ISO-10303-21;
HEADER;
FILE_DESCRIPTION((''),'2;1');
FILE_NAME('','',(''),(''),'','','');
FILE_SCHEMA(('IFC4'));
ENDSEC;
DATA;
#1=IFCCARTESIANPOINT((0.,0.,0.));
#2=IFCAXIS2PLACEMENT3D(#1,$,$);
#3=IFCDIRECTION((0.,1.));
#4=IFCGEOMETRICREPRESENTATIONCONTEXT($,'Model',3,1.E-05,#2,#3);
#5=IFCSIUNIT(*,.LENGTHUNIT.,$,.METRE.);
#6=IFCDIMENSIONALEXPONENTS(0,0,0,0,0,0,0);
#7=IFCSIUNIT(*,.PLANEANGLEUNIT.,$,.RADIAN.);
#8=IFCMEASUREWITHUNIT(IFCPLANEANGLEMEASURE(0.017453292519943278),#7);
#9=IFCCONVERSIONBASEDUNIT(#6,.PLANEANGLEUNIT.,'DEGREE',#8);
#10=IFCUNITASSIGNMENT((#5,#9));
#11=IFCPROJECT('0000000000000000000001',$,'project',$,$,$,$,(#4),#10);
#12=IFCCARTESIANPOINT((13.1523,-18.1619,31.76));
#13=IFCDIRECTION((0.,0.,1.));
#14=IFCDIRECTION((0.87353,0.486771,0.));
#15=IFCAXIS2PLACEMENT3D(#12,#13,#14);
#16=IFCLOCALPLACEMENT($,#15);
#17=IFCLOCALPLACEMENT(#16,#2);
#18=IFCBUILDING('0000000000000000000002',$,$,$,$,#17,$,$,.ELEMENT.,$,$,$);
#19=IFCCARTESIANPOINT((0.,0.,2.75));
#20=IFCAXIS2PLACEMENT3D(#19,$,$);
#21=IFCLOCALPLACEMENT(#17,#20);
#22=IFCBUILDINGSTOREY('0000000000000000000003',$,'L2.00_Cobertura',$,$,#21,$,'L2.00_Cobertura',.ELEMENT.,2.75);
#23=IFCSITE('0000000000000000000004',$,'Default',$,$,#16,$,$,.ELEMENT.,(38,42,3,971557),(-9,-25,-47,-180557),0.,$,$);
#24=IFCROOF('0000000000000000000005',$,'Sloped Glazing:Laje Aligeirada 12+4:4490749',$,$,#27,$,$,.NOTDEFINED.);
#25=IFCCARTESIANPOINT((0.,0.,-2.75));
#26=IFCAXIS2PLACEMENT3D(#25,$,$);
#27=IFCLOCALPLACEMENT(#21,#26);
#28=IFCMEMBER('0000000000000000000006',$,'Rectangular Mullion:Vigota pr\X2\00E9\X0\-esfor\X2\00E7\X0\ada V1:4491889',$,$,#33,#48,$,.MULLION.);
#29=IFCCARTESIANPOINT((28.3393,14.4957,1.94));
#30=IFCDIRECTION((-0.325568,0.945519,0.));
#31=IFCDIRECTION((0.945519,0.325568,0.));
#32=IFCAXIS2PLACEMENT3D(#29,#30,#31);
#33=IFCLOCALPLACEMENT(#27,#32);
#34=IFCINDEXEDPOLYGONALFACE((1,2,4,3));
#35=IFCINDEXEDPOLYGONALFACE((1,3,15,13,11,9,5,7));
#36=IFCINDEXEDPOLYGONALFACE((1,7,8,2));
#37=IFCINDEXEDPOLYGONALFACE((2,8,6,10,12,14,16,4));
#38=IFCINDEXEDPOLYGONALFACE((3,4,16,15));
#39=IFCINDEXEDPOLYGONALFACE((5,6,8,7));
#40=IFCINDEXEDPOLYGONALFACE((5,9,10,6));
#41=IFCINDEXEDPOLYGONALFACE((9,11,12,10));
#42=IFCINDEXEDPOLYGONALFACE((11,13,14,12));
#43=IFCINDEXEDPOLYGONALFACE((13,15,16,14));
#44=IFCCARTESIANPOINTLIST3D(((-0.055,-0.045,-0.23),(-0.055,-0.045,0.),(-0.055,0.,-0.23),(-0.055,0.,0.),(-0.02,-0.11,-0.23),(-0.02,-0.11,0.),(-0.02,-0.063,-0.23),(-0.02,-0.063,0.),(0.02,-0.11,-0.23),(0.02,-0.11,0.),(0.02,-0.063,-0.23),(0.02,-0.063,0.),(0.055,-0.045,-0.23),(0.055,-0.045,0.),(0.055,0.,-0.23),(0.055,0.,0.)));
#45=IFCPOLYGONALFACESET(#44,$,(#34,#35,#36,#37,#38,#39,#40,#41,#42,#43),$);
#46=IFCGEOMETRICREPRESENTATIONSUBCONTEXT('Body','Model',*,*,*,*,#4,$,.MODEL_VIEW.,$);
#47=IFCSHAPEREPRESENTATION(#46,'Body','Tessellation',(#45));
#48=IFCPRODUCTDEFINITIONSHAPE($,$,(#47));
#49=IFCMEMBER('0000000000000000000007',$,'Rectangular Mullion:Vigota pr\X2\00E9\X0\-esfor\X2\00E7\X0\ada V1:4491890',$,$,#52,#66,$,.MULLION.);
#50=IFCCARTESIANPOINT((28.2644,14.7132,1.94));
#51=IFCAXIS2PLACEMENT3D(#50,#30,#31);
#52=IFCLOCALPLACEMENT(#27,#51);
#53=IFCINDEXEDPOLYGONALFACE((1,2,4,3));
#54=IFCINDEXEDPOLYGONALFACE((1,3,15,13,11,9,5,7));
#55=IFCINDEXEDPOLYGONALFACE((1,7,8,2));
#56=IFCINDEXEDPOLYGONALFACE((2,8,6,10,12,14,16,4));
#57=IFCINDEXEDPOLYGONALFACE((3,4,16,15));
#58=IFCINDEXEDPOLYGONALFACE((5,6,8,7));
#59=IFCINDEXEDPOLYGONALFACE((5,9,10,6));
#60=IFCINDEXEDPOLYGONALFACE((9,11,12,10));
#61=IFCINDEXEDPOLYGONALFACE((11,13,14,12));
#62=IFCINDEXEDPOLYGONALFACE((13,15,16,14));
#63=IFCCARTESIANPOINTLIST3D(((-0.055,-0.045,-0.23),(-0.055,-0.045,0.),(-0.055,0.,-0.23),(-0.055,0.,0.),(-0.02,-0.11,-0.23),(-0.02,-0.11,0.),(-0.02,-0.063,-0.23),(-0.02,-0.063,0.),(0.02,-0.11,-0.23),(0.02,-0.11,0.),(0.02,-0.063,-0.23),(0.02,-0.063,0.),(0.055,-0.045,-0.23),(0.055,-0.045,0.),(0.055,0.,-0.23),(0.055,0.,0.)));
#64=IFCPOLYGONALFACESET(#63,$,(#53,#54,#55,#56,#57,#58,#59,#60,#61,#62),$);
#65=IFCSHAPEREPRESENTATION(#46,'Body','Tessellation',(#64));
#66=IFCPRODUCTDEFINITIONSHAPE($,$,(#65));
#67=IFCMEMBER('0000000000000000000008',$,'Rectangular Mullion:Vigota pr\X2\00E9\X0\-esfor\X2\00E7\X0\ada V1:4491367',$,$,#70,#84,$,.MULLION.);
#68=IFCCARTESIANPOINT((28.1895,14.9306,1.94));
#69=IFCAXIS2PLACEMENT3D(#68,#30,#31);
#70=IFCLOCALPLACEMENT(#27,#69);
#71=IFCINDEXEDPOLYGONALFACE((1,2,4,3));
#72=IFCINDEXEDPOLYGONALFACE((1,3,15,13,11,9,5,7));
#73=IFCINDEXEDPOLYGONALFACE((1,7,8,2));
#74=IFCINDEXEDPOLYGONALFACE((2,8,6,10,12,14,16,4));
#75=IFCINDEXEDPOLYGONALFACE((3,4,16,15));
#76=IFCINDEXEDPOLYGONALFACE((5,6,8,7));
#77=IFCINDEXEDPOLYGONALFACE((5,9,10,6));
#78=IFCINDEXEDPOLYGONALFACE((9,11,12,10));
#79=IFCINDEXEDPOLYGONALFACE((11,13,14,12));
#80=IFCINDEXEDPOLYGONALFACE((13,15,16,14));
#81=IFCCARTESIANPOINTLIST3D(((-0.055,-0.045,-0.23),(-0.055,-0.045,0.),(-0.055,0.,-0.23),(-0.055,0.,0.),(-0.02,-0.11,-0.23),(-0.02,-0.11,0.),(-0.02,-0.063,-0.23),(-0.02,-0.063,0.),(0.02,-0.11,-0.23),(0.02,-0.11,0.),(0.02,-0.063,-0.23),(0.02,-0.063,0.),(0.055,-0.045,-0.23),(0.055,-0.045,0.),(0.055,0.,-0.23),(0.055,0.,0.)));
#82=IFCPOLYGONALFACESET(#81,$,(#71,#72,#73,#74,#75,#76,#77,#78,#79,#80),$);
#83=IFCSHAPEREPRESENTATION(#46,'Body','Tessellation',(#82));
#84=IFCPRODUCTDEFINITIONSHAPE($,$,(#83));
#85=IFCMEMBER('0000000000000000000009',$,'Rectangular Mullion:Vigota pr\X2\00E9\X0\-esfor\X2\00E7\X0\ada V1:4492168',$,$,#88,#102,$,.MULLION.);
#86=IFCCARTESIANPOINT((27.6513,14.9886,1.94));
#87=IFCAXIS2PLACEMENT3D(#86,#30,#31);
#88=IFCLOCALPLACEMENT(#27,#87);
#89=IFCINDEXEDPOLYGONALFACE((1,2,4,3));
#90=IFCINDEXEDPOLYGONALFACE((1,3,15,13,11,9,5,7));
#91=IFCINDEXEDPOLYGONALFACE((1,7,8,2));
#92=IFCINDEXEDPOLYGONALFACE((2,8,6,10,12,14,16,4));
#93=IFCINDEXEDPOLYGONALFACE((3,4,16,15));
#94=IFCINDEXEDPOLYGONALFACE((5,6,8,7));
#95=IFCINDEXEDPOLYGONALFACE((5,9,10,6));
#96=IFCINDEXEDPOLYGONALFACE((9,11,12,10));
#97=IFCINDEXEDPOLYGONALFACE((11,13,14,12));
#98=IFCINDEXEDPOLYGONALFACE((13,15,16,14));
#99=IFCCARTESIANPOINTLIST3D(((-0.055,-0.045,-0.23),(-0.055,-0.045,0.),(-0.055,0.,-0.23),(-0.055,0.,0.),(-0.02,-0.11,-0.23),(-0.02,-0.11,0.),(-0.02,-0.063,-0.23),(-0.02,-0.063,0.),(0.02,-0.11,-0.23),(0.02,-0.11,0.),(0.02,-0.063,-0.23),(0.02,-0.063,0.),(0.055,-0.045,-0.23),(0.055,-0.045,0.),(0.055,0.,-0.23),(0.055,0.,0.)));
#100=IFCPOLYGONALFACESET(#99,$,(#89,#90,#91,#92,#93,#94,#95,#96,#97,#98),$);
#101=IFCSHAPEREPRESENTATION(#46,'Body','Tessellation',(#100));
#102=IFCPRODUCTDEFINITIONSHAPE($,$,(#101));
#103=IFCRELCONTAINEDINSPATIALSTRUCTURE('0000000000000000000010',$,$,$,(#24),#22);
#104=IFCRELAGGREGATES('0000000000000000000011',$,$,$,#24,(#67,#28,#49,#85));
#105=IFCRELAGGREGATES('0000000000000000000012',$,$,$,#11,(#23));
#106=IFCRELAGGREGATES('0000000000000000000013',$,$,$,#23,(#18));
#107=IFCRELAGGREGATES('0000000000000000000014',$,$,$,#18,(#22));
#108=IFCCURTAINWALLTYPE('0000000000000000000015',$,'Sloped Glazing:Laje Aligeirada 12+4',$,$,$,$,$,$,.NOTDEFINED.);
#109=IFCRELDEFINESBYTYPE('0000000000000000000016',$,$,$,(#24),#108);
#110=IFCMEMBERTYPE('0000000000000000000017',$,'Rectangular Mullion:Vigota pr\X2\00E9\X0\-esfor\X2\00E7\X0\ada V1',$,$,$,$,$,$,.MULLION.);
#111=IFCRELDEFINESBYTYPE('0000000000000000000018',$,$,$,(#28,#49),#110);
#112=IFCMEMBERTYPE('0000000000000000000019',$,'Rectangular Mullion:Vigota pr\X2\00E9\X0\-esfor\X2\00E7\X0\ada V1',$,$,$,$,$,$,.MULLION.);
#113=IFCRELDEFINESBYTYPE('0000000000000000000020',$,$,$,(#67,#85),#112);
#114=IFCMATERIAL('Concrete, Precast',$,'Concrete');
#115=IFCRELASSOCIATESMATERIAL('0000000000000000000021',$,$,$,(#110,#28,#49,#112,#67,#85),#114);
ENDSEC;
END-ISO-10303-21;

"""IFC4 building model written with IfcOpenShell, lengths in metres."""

from ifc_helpers import new_model, entity, si_unit, converted_unit, direction, frame, origin, place, context, subcontext, project, spatial, indexed_curve, outline, extrude, source, transform, mapped, material, type_object, type_shapes, element, aggregate, save


model = new_model("IFC4")

# Units and contexts
model_context = context("Model", 3, precision=1e-05, world=origin(), true_north=direction((0.0, 1.0)))
body_context = subcontext(model_context, "Body", "Model", "MODEL_VIEW")
ifc_project = project(units=[si_unit("LENGTHUNIT", "METRE"), converted_unit("PLANEANGLEUNIT", "DEGREE", entity("IfcPlaneAngleMeasure", 0.017453292519943278), si_unit("PLANEANGLEUNIT", "RADIAN"), dimensions=[0, 0, 0, 0, 0, 0, 0])], contexts=[model_context])

# Site, building, storey
site_placement = place(None, frame((13.1523, -18.1619, 31.76), z_axis=(0.0, 0.0, 1.0), x_axis=(0.87353, 0.486771, 0.0)))
site = spatial("IfcSite", under=ifc_project, at=site_placement, Name="Default", CompositionType="ELEMENT", RefLatitude=(38, 42, 3, 971557), RefLongitude=(-9, -25, -47, -180557), RefElevation=0.0)
building_placement = place(site_placement, origin())
building = spatial("IfcBuilding", under=site, at=building_placement, CompositionType="ELEMENT")
storey_placement = place(building_placement, frame((0.0, 0.0, 2.75)))
storey = spatial("IfcBuildingStorey", under=building, at=storey_placement, Name="L2.00_Cobertura", LongName="L2.00_Cobertura", CompositionType="ELEMENT", Elevation=2.75)

# Roof, members
curtain_wall_type = type_object("IfcCurtainWallType", Name="Sloped Glazing:Laje Aligeirada 12+4", PredefinedType="NOTDEFINED")
roof_placement = place(storey_placement, frame((0.0, 0.0, -2.75)))
roof = element("IfcRoof", 1, at=roof_placement, inside=storey, type_object=curtain_wall_type, Name="Sloped Glazing:Laje Aligeirada 12+4:4490749", PredefinedType="NOTDEFINED")
ifc_material_1 = material(Name="Concrete, Precast", Category="Concrete")
member_type_1 = type_object("IfcMemberType", Name="Rectangular Mullion:Vigota pré-esforçada V1", PredefinedType="MULLION", material=ifc_material_1)
shared_shape_1 = source(origin(), body_context, "Body", "SweptSolid", [
    extrude(outline(indexed_curve([(-0.055, -0.0545), (0.055, -0.0545), (0.055, -0.0095), (0.02, 0.0085), (0.02, 0.0555), (-0.02, 0.0555), (-0.02, 0.0085), (-0.055, -0.0095), (-0.055, -0.0545)], self_intersect=False)), frame((0.0, -0.0545, -0.23), z_axis=(0.0, 0.0, 1.0), x_axis=(-1.0, 0.0, 0.0)), (0.0, 0.0, 1.0), 0.23),
])
type_shapes(member_type_1, [shared_shape_1])
member_1_placement = place(roof_placement, frame((28.3393, 14.4957, 1.94), z_axis=(-0.325568, 0.945519, 0.0), x_axis=(0.945519, 0.325568, 0.0)))
member_1 = element("IfcMember", 2, at=member_1_placement, type_object=member_type_1, material=ifc_material_1, Name="Rectangular Mullion:Vigota pré-esforçada V1:4491889", PredefinedType="MULLION", context=body_context, shape_type="MappedRepresentation", body=[
    mapped(shared_shape_1, transform((0.0, 0.0, 0.0), scale=1.0)),
])
member_2_placement = place(roof_placement, frame((28.2644, 14.7132, 1.94), z_axis=(-0.325568, 0.945519, 0.0), x_axis=(0.945519, 0.325568, 0.0)))
member_2 = element("IfcMember", 3, at=member_2_placement, type_object=member_type_1, material=ifc_material_1, Name="Rectangular Mullion:Vigota pré-esforçada V1:4491890", PredefinedType="MULLION", context=body_context, shape_type="MappedRepresentation", body=[
    mapped(shared_shape_1, transform((0.0, 0.0, 0.0), scale=1.0)),
])
member_type_2 = type_object("IfcMemberType", Name="Rectangular Mullion:Vigota pré-esforçada V1", PredefinedType="MULLION", material=ifc_material_1)
shared_shape_2 = source(origin(), body_context, "Body", "SweptSolid", [
    extrude(outline(indexed_curve([(-0.055, -0.0545), (0.055, -0.0545), (0.055, -0.0095), (0.02, 0.0085), (0.02, 0.0555), (-0.02, 0.0555), (-0.02, 0.0085), (-0.055, -0.0095), (-0.055, -0.0545)], self_intersect=False)), frame((0.0, -0.0545, -0.23), z_axis=(0.0, 0.0, 1.0), x_axis=(-1.0, 0.0, 0.0)), (0.0, 0.0, 1.0), 0.23),
])
type_shapes(member_type_2, [shared_shape_2])
member_3_placement = place(roof_placement, frame((28.1895, 14.9306, 1.94), z_axis=(-0.325568, 0.945519, 0.0), x_axis=(0.945519, 0.325568, 0.0)))
member_3 = element("IfcMember", 4, at=member_3_placement, type_object=member_type_2, material=ifc_material_1, Name="Rectangular Mullion:Vigota pré-esforçada V1:4491367", PredefinedType="MULLION", context=body_context, shape_type="MappedRepresentation", body=[
    mapped(shared_shape_2, transform((0.0, 0.0, 0.0), scale=1.0)),
])
member_4_placement = place(roof_placement, frame((27.6513, 14.9886, 1.94), z_axis=(-0.325568, 0.945519, 0.0), x_axis=(0.945519, 0.325568, 0.0)))
member_4 = element("IfcMember", 5, at=member_4_placement, type_object=member_type_2, material=ifc_material_1, Name="Rectangular Mullion:Vigota pré-esforçada V1:4492168", PredefinedType="MULLION", context=body_context, shape_type="MappedRepresentation", body=[
    mapped(shared_shape_2, transform((0.0, 0.0, 0.0), scale=1.0)),
])
aggregate(roof, [member_3, member_1, member_2, member_4])

save(model, "model.ifc")
